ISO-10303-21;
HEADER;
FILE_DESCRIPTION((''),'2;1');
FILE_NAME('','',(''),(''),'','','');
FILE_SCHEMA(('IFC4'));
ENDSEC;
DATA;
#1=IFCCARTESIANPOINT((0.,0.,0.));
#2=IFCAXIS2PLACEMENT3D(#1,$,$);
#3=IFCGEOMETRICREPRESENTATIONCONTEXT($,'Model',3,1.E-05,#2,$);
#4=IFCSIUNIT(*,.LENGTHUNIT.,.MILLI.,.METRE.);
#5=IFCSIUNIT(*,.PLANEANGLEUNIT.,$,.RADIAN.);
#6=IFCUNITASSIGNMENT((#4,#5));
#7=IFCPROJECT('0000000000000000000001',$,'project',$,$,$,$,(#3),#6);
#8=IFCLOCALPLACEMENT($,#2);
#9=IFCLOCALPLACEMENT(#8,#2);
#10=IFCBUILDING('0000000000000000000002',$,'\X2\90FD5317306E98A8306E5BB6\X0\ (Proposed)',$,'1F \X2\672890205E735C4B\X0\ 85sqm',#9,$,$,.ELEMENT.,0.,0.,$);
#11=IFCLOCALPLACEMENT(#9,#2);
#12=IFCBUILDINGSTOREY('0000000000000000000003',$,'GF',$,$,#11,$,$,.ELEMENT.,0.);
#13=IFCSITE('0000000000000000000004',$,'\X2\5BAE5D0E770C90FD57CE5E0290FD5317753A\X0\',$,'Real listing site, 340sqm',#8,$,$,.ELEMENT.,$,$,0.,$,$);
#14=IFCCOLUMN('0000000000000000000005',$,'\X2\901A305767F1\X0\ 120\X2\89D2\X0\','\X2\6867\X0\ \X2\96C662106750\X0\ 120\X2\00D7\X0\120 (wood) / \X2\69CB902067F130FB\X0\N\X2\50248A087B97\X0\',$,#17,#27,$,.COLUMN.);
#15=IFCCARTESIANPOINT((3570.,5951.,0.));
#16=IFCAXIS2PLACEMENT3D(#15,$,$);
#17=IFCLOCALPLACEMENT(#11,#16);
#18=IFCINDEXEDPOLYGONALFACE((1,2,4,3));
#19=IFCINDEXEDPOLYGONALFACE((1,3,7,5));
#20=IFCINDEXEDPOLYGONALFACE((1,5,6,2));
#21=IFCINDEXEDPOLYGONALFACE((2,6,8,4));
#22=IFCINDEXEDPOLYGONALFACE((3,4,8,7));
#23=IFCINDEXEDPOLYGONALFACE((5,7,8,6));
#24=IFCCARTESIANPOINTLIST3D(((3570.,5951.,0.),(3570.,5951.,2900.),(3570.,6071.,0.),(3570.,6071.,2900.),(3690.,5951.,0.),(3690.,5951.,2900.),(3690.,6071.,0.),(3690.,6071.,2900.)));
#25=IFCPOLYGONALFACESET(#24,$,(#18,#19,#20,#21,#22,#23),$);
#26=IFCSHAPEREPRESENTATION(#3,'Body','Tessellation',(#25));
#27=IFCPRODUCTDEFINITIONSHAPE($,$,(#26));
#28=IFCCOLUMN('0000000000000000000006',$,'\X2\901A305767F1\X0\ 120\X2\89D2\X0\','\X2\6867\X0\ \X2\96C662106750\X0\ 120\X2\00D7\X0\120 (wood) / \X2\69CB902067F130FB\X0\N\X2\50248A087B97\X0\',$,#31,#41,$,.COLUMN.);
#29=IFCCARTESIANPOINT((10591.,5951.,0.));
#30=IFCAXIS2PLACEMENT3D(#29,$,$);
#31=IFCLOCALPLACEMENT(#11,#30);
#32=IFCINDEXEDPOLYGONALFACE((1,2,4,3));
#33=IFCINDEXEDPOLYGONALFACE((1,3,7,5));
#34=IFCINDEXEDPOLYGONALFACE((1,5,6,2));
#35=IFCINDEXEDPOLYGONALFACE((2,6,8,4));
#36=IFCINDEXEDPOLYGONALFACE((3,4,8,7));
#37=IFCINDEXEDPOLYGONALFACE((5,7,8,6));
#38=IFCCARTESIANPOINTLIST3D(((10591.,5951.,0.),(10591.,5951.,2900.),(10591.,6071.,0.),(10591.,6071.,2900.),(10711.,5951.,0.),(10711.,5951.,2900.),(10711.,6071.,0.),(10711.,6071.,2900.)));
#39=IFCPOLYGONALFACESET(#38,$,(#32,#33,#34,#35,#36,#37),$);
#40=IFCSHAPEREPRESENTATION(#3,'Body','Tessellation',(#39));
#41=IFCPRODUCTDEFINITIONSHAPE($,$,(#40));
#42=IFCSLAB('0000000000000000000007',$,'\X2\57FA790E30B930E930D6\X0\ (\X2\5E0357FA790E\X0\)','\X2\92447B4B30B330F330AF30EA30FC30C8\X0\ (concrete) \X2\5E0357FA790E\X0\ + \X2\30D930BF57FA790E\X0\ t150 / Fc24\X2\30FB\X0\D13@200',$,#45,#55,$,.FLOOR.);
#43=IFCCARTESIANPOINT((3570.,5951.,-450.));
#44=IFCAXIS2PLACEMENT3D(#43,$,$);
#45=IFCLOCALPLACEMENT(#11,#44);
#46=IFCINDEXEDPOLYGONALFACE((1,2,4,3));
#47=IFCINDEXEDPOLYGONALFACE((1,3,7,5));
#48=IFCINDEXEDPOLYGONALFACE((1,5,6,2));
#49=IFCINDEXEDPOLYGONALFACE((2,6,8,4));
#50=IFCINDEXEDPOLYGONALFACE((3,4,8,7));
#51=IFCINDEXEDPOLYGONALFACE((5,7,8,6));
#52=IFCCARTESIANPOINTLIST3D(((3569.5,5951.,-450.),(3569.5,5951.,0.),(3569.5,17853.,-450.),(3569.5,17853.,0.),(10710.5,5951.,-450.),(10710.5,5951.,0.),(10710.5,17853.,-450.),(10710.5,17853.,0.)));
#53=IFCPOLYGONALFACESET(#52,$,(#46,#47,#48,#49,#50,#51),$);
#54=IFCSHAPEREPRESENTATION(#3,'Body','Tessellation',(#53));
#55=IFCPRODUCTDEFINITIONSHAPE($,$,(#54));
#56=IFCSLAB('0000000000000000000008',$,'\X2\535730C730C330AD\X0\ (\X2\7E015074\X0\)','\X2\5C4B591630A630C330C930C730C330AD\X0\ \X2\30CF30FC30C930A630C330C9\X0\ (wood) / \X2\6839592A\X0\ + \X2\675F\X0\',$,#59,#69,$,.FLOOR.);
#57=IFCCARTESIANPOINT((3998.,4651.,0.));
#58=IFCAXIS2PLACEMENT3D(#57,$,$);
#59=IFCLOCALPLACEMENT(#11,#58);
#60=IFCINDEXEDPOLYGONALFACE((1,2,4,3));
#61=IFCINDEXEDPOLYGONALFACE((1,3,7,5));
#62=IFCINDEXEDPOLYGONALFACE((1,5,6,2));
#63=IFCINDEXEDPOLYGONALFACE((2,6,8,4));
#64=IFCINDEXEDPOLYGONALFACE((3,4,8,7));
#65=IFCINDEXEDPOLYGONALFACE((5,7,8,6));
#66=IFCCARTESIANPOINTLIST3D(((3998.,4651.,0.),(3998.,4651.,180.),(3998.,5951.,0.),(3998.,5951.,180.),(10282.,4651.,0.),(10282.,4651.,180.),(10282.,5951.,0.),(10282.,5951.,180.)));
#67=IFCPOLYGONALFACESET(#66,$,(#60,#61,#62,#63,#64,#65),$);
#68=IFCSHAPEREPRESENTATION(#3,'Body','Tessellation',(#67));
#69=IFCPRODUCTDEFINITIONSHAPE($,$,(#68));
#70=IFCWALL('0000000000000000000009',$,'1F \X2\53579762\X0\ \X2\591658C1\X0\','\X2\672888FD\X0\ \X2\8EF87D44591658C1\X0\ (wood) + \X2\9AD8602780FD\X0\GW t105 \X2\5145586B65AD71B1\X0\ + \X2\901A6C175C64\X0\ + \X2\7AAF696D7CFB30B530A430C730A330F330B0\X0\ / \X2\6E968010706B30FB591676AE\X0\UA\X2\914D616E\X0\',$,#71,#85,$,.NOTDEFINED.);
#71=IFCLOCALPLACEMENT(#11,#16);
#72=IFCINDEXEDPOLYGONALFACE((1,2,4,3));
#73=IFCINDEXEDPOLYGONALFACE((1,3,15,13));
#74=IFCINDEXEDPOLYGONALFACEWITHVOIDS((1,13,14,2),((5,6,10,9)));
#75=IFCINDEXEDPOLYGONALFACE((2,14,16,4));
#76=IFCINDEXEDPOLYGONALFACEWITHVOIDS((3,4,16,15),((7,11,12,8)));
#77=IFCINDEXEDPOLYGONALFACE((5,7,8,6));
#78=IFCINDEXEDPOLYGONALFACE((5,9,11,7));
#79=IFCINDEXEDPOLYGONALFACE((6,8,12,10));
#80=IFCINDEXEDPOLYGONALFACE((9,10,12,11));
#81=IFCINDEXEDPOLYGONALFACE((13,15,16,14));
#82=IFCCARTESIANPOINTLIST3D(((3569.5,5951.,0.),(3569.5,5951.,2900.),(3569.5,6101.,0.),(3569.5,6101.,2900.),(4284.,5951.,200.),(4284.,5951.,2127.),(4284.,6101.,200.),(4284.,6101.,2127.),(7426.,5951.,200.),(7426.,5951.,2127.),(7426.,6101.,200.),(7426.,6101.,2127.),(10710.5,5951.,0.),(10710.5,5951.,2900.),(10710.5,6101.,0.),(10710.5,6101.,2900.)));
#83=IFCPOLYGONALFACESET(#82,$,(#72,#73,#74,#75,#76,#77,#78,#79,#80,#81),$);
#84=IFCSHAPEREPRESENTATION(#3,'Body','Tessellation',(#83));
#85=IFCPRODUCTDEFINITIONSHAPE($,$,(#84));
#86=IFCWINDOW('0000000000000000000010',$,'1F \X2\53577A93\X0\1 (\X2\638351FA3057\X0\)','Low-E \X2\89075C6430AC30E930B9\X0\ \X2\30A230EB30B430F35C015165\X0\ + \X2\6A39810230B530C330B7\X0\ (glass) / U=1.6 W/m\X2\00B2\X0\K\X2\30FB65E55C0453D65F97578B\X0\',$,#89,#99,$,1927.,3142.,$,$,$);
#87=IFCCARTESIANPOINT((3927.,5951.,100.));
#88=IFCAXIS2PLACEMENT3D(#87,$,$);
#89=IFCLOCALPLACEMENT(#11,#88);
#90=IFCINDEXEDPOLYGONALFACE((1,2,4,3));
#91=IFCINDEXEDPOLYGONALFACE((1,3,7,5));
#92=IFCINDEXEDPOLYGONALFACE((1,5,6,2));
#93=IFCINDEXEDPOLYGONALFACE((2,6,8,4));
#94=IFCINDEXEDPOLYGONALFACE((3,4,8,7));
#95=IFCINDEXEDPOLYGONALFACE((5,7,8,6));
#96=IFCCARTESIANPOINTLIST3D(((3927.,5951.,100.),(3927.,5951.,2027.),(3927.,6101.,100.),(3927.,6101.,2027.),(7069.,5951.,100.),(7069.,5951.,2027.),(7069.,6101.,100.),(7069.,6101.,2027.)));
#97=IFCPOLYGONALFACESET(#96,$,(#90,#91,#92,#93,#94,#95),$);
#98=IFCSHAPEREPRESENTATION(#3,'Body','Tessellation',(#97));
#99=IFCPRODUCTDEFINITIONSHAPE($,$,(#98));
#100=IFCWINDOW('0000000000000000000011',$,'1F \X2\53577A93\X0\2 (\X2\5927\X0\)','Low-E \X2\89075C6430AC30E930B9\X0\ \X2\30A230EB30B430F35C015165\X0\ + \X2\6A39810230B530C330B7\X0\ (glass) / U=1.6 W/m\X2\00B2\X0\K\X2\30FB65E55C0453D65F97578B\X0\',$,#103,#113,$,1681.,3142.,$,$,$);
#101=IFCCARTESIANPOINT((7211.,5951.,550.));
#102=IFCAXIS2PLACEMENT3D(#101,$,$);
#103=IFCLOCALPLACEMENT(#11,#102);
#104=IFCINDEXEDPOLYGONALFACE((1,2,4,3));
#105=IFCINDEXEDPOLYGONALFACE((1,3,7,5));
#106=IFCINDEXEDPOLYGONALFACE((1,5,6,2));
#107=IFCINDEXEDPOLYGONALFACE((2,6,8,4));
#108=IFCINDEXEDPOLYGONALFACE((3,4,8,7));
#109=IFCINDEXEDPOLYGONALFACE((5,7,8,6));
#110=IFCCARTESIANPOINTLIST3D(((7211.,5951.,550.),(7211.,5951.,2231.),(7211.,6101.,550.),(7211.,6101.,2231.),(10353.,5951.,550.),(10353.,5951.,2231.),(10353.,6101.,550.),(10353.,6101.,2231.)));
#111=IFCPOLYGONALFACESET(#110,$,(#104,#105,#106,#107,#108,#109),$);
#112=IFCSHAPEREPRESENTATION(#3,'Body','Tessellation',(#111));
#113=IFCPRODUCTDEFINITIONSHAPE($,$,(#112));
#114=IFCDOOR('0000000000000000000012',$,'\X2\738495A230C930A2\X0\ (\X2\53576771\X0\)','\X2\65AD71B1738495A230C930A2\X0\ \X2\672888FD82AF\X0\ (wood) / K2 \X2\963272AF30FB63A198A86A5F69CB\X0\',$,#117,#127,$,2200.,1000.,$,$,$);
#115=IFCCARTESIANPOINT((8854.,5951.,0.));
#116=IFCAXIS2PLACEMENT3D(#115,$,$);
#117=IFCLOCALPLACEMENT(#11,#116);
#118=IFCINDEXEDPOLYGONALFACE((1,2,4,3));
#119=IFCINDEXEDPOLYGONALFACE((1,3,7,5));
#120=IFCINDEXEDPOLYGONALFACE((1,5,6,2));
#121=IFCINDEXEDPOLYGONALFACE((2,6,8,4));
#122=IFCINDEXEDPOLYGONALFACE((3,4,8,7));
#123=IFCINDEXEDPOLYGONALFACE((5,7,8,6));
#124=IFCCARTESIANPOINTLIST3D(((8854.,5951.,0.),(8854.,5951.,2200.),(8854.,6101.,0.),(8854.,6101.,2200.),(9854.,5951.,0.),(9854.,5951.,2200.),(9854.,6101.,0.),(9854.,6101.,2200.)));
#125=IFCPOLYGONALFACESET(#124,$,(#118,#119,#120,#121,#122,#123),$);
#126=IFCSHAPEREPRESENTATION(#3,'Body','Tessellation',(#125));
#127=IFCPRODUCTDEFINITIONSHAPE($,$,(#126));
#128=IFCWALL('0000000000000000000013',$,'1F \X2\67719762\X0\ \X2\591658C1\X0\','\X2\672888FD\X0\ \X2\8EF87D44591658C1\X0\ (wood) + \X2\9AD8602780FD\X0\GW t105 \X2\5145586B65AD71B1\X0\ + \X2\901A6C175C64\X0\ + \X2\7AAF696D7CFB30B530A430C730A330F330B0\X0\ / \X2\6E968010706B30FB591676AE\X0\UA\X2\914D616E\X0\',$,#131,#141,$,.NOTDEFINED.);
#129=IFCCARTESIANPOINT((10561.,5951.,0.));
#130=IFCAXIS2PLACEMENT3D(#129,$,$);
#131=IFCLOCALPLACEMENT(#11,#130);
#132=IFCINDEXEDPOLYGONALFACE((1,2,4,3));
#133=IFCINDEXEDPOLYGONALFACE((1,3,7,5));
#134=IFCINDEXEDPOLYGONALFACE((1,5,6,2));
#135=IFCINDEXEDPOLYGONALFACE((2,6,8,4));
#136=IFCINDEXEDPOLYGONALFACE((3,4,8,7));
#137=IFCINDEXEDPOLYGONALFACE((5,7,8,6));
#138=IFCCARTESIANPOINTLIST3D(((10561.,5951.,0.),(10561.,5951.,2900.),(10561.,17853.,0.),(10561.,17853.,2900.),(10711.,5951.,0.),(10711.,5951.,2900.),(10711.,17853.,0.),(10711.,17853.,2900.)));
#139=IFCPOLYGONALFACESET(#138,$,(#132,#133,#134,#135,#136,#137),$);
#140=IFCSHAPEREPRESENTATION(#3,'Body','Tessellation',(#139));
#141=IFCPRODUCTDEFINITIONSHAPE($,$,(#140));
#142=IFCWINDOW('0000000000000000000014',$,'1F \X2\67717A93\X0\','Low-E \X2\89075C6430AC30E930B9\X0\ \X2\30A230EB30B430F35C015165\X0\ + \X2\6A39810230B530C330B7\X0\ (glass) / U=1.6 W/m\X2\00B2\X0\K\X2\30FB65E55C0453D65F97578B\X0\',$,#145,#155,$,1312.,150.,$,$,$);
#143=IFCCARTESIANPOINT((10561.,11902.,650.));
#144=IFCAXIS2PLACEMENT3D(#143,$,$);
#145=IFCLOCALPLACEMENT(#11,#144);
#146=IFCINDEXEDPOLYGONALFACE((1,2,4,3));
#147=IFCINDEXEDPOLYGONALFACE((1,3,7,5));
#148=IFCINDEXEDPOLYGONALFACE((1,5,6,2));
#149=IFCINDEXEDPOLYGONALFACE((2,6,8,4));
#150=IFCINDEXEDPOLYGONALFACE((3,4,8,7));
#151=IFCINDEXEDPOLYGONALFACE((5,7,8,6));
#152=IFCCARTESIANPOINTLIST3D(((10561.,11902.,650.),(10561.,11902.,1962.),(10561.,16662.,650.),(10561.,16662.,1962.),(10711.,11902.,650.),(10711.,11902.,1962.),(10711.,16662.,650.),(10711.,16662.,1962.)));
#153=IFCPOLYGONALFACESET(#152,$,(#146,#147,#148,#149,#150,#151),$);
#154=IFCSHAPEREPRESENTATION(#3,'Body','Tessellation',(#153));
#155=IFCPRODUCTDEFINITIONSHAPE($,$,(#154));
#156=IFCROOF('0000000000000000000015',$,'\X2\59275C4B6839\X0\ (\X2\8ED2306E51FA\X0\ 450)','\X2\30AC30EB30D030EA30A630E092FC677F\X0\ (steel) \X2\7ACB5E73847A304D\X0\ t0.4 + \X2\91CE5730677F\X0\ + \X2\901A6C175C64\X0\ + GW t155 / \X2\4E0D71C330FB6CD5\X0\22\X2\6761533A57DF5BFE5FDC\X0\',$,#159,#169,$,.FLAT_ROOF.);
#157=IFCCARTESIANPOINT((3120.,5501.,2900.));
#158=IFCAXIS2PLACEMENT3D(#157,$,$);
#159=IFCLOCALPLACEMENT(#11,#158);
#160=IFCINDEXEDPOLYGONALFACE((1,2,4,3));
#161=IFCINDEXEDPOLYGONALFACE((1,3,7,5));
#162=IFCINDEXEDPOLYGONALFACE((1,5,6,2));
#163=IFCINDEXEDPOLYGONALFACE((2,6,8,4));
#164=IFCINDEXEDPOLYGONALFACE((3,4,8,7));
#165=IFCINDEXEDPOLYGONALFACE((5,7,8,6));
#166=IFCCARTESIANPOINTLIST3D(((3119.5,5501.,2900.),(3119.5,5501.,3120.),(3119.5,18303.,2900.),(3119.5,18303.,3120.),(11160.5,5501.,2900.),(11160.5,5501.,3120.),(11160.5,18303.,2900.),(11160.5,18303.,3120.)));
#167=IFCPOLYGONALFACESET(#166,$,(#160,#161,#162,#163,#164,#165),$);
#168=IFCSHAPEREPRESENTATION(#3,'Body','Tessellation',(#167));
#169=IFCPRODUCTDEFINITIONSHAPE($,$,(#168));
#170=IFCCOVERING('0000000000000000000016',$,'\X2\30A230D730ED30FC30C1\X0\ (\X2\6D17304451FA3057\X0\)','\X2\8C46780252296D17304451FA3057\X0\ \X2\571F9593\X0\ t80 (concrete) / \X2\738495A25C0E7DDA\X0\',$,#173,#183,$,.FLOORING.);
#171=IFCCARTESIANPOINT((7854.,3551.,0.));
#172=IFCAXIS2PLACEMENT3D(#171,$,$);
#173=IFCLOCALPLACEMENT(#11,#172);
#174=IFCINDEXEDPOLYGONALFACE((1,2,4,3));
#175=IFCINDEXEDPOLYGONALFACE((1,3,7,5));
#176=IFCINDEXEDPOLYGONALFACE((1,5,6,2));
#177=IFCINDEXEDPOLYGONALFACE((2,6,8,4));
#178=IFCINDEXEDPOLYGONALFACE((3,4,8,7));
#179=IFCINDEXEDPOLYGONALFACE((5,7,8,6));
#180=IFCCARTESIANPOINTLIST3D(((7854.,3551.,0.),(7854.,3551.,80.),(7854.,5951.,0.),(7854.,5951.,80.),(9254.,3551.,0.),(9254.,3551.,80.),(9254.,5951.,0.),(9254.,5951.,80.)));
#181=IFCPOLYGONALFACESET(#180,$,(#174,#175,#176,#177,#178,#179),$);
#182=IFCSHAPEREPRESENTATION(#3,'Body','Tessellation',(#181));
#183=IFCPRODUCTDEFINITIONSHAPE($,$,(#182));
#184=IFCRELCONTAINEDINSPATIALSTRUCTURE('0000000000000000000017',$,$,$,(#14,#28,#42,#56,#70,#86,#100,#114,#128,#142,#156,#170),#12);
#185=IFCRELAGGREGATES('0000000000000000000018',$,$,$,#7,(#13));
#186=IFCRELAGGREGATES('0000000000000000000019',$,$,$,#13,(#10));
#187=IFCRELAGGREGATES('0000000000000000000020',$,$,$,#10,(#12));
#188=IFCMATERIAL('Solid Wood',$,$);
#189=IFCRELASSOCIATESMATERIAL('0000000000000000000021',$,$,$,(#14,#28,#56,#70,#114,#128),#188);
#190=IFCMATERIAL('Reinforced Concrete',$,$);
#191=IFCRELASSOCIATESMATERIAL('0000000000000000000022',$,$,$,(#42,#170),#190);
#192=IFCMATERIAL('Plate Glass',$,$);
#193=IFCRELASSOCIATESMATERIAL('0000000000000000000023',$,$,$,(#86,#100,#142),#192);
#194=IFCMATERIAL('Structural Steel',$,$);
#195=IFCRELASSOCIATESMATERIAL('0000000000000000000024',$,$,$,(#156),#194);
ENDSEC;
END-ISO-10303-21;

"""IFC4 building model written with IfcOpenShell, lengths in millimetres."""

from ifc_helpers import new_model, si_unit, frame, frame_2d, origin, place, context, project, spatial, rectangle, extrude, material, element, fill, save


model = new_model("IFC4")

# Units and contexts
model_context = context("Model", 3, precision=1e-05, world=origin())
ifc_project = project(units=[si_unit("LENGTHUNIT", "METRE", prefix="MILLI"), si_unit("PLANEANGLEUNIT", "RADIAN")], contexts=[model_context])

# Site, building, storey
site_placement = place(None, origin())
site = spatial("IfcSite", under=ifc_project, at=site_placement, Name="宮崎県都城市都北町", ObjectType="Real listing site, 340sqm", CompositionType="ELEMENT", RefElevation=0.0)
building_placement = place(site_placement, origin())
building = spatial("IfcBuilding", under=site, at=building_placement, Name="都北の風の家 (Proposed)", ObjectType="1F 木造平屋 85sqm", CompositionType="ELEMENT", ElevationOfRefHeight=0.0, ElevationOfTerrain=0.0)
storey_placement = place(building_placement, origin())
storey = spatial("IfcBuildingStorey", under=building, at=storey_placement, Name="GF", CompositionType="ELEMENT", Elevation=0.0)

# Columns
ifc_material_1 = material(Name="Solid Wood")
column_1_placement = place(storey_placement, frame((3570.0, 5951.0, 0.0)))
element("IfcColumn", 1, at=column_1_placement, inside=storey, material=ifc_material_1, Name="通し柱 120角", Description="桧 集成材 120×120 (wood) / 構造柱・N値計算", PredefinedType="COLUMN", context=model_context, shape_type="SweptSolid", body=[
    extrude(rectangle(XDim=120.0, YDim=120.0, at=frame_2d((60.0, 60.0))), frame((3570.0, 5951.0, 0.0)), (0.0, 0.0, 1.0), 2900.0),
])
column_2_placement = place(storey_placement, frame((10591.0, 5951.0, 0.0)))
element("IfcColumn", 2, at=column_2_placement, inside=storey, material=ifc_material_1, Name="通し柱 120角", Description="桧 集成材 120×120 (wood) / 構造柱・N値計算", PredefinedType="COLUMN", context=model_context, shape_type="SweptSolid", body=[
    extrude(rectangle(XDim=120.0, YDim=120.0, at=frame_2d((60.0, 60.0))), frame((10591.0, 5951.0, 0.0)), (0.0, 0.0, 1.0), 2900.0),
])

# Slabs
ifc_material_2 = material(Name="Reinforced Concrete")
slab_1_placement = place(storey_placement, frame((3570.0, 5951.0, -450.0)))
element("IfcSlab", 3, at=slab_1_placement, inside=storey, material=ifc_material_2, Name="基礎スラブ (布基礎)", Description="鉄筋コンクリート (concrete) 布基礎 + ベタ基礎 t150 / Fc24・D13@200", PredefinedType="FLOOR", context=model_context, shape_type="SweptSolid", body=[
    extrude(rectangle(XDim=7141.0, YDim=11902.0, at=frame_2d((3570.0, 5951.0))), frame((3570.0, 5951.0, -450.0)), (0.0, 0.0, 1.0), 450.0),
])
slab_2_placement = place(storey_placement, frame((3998.0, 4651.0, 0.0)))
element("IfcSlab", 4, at=slab_2_placement, inside=storey, material=ifc_material_1, Name="南デッキ (縁側)", Description="屋外ウッドデッキ ハードウッド (wood) / 根太 + 束", PredefinedType="FLOOR", context=model_context, shape_type="SweptSolid", body=[
    extrude(rectangle(XDim=6284.0, YDim=1300.0, at=frame_2d((3142.0, 650.0))), frame((3998.0, 4651.0, 0.0)), (0.0, 0.0, 1.0), 180.0),
])

# Wall, openings, windows, door
wall_1_placement = place(storey_placement, frame((3570.0, 5951.0, 0.0)))
wall_1 = element("IfcWall", 5, at=wall_1_placement, inside=storey, material=ifc_material_1, Name="1F 南面 外壁", Description="木製 軸組外壁 (wood) + 高性能GW t105 充填断熱 + 通気層 + 窯業系サイディング / 準耐火・外皮UA配慮", PredefinedType="NOTDEFINED", context=model_context, shape_type="SweptSolid", body=[
    extrude(rectangle(XDim=7141.0, YDim=150.0, at=frame_2d((3570.0, 75.0))), frame((3570.0, 5951.0, 0.0)), (0.0, 0.0, 1.0), 2900.0),
])
opening_1_placement = place(storey_placement, frame((3927.0, 5951.0, 100.0)))
opening_1 = element("IfcOpeningElement", 6, at=opening_1_placement, cuts=wall_1, PredefinedType="NOTDEFINED", context=model_context, shape_type="SweptSolid", body=[
    extrude(rectangle(XDim=3142.0, YDim=150.0, at=frame_2d((1571.0, 75.0))), frame((3927.0, 5951.0, 100.0)), (0.0, 0.0, 1.0), 1927.0),
])
opening_2_placement = place(storey_placement, frame((7211.0, 5951.0, 550.0)))
opening_2 = element("IfcOpeningElement", 7, at=opening_2_placement, cuts=wall_1, PredefinedType="NOTDEFINED", context=model_context, shape_type="SweptSolid", body=[
    extrude(rectangle(XDim=3142.0, YDim=150.0, at=frame_2d((1571.0, 75.0))), frame((7211.0, 5951.0, 550.0)), (0.0, 0.0, 1.0), 1681.0),
])
opening_3_placement = place(storey_placement, frame((8854.0, 5951.0, 0.0)))
opening_3 = element("IfcOpeningElement", 8, at=opening_3_placement, cuts=wall_1, PredefinedType="NOTDEFINED", context=model_context, shape_type="SweptSolid", body=[
    extrude(rectangle(XDim=1000.0, YDim=150.0, at=frame_2d((500.0, 75.0))), frame((8854.0, 5951.0, 0.0)), (0.0, 0.0, 1.0), 2200.0),
])
ifc_material_3 = material(Name="Plate Glass")
window_1_placement = place(storey_placement, frame((3927.0, 5951.0, 100.0)))
window_1 = element("IfcWindow", 9, at=window_1_placement, inside=storey, material=ifc_material_3, Name="1F 南窓1 (掃出し)", Description="Low-E 複層ガラス アルゴン封入 + 樹脂サッシ (glass) / U=1.6 W/m²K・日射取得型", OverallHeight=1927.0, OverallWidth=3142.0, context=model_context, shape_type="SweptSolid", body=[
    extrude(rectangle(XDim=3142.0, YDim=150.0, at=frame_2d((1571.0, 75.0))), frame((3927.0, 5951.0, 100.0)), (0.0, 0.0, 1.0), 1927.0),
])
fill(opening_1, window_1)
window_2_placement = place(storey_placement, frame((7211.0, 5951.0, 550.0)))
window_2 = element("IfcWindow", 10, at=window_2_placement, inside=storey, material=ifc_material_3, Name="1F 南窓2 (大)", Description="Low-E 複層ガラス アルゴン封入 + 樹脂サッシ (glass) / U=1.6 W/m²K・日射取得型", OverallHeight=1681.0, OverallWidth=3142.0, context=model_context, shape_type="SweptSolid", body=[
    extrude(rectangle(XDim=3142.0, YDim=150.0, at=frame_2d((1571.0, 75.0))), frame((7211.0, 5951.0, 550.0)), (0.0, 0.0, 1.0), 1681.0),
])
fill(opening_2, window_2)
door_placement = place(storey_placement, frame((8854.0, 5951.0, 0.0)))
door = element("IfcDoor", 11, at=door_placement, inside=storey, material=ifc_material_1, Name="玄関ドア (南東)", Description="断熱玄関ドア 木製芯 (wood) / K2 防犯・採風機構", OverallHeight=2200.0, OverallWidth=1000.0, context=model_context, shape_type="SweptSolid", body=[
    extrude(rectangle(XDim=1000.0, YDim=150.0, at=frame_2d((500.0, 75.0))), frame((8854.0, 5951.0, 0.0)), (0.0, 0.0, 1.0), 2200.0),
])
fill(opening_3, door)

# Wall, opening, window
wall_2_placement = place(storey_placement, frame((10561.0, 5951.0, 0.0)))
wall_2 = element("IfcWall", 12, at=wall_2_placement, inside=storey, material=ifc_material_1, Name="1F 東面 外壁", Description="木製 軸組外壁 (wood) + 高性能GW t105 充填断熱 + 通気層 + 窯業系サイディング / 準耐火・外皮UA配慮", PredefinedType="NOTDEFINED", context=model_context, shape_type="SweptSolid", body=[
    extrude(rectangle(XDim=150.0, YDim=11902.0, at=frame_2d((75.0, 5951.0))), frame((10561.0, 5951.0, 0.0)), (0.0, 0.0, 1.0), 2900.0),
])
opening_4_placement = place(storey_placement, frame((10561.0, 11902.0, 650.0)))
opening_4 = element("IfcOpeningElement", 13, at=opening_4_placement, cuts=wall_2, PredefinedType="NOTDEFINED", context=model_context, shape_type="SweptSolid", body=[
    extrude(rectangle(XDim=150.0, YDim=4760.0, at=frame_2d((75.0, 2380.0))), frame((10561.0, 11902.0, 650.0)), (0.0, 0.0, 1.0), 1312.0),
])
window_3_placement = place(storey_placement, frame((10561.0, 11902.0, 650.0)))
window_3 = element("IfcWindow", 14, at=window_3_placement, inside=storey, material=ifc_material_3, Name="1F 東窓", Description="Low-E 複層ガラス アルゴン封入 + 樹脂サッシ (glass) / U=1.6 W/m²K・日射取得型", OverallHeight=1312.0, OverallWidth=150.0, context=model_context, shape_type="SweptSolid", body=[
    extrude(rectangle(XDim=150.0, YDim=4760.0, at=frame_2d((75.0, 2380.0))), frame((10561.0, 11902.0, 650.0)), (0.0, 0.0, 1.0), 1312.0),
])
fill(opening_4, window_3)

# Roof
ifc_material_4 = material(Name="Structural Steel")
roof_placement = place(storey_placement, frame((3120.0, 5501.0, 2900.0)))
element("IfcRoof", 15, at=roof_placement, inside=storey, material=ifc_material_4, Name="大屋根 (軒の出 450)", Description="ガルバリウム鋼板 (steel) 立平葺き t0.4 + 野地板 + 通気層 + GW t155 / 不燃・法22条区域対応", PredefinedType="FLAT_ROOF", context=model_context, shape_type="SweptSolid", body=[
    extrude(rectangle(XDim=8041.0, YDim=12802.0, at=frame_2d((4020.0, 6401.0))), frame((3120.0, 5501.0, 2900.0)), (0.0, 0.0, 1.0), 220.0),
])

# Covering
covering_1_placement = place(storey_placement, frame((7854.0, 3551.0, 0.0)))
element("IfcCovering", 16, at=covering_1_placement, inside=storey, material=ifc_material_2, Name="アプローチ (洗い出し)", Description="豆砂利洗い出し 土間 t80 (concrete) / 玄関導線", PredefinedType="FLOORING", context=model_context, shape_type="SweptSolid", body=[
    extrude(rectangle(XDim=1400.0, YDim=2400.0, at=frame_2d((700.0, 1200.0))), frame((7854.0, 3551.0, 0.0)), (0.0, 0.0, 1.0), 80.0),
])

save(model, "model.ifc")
